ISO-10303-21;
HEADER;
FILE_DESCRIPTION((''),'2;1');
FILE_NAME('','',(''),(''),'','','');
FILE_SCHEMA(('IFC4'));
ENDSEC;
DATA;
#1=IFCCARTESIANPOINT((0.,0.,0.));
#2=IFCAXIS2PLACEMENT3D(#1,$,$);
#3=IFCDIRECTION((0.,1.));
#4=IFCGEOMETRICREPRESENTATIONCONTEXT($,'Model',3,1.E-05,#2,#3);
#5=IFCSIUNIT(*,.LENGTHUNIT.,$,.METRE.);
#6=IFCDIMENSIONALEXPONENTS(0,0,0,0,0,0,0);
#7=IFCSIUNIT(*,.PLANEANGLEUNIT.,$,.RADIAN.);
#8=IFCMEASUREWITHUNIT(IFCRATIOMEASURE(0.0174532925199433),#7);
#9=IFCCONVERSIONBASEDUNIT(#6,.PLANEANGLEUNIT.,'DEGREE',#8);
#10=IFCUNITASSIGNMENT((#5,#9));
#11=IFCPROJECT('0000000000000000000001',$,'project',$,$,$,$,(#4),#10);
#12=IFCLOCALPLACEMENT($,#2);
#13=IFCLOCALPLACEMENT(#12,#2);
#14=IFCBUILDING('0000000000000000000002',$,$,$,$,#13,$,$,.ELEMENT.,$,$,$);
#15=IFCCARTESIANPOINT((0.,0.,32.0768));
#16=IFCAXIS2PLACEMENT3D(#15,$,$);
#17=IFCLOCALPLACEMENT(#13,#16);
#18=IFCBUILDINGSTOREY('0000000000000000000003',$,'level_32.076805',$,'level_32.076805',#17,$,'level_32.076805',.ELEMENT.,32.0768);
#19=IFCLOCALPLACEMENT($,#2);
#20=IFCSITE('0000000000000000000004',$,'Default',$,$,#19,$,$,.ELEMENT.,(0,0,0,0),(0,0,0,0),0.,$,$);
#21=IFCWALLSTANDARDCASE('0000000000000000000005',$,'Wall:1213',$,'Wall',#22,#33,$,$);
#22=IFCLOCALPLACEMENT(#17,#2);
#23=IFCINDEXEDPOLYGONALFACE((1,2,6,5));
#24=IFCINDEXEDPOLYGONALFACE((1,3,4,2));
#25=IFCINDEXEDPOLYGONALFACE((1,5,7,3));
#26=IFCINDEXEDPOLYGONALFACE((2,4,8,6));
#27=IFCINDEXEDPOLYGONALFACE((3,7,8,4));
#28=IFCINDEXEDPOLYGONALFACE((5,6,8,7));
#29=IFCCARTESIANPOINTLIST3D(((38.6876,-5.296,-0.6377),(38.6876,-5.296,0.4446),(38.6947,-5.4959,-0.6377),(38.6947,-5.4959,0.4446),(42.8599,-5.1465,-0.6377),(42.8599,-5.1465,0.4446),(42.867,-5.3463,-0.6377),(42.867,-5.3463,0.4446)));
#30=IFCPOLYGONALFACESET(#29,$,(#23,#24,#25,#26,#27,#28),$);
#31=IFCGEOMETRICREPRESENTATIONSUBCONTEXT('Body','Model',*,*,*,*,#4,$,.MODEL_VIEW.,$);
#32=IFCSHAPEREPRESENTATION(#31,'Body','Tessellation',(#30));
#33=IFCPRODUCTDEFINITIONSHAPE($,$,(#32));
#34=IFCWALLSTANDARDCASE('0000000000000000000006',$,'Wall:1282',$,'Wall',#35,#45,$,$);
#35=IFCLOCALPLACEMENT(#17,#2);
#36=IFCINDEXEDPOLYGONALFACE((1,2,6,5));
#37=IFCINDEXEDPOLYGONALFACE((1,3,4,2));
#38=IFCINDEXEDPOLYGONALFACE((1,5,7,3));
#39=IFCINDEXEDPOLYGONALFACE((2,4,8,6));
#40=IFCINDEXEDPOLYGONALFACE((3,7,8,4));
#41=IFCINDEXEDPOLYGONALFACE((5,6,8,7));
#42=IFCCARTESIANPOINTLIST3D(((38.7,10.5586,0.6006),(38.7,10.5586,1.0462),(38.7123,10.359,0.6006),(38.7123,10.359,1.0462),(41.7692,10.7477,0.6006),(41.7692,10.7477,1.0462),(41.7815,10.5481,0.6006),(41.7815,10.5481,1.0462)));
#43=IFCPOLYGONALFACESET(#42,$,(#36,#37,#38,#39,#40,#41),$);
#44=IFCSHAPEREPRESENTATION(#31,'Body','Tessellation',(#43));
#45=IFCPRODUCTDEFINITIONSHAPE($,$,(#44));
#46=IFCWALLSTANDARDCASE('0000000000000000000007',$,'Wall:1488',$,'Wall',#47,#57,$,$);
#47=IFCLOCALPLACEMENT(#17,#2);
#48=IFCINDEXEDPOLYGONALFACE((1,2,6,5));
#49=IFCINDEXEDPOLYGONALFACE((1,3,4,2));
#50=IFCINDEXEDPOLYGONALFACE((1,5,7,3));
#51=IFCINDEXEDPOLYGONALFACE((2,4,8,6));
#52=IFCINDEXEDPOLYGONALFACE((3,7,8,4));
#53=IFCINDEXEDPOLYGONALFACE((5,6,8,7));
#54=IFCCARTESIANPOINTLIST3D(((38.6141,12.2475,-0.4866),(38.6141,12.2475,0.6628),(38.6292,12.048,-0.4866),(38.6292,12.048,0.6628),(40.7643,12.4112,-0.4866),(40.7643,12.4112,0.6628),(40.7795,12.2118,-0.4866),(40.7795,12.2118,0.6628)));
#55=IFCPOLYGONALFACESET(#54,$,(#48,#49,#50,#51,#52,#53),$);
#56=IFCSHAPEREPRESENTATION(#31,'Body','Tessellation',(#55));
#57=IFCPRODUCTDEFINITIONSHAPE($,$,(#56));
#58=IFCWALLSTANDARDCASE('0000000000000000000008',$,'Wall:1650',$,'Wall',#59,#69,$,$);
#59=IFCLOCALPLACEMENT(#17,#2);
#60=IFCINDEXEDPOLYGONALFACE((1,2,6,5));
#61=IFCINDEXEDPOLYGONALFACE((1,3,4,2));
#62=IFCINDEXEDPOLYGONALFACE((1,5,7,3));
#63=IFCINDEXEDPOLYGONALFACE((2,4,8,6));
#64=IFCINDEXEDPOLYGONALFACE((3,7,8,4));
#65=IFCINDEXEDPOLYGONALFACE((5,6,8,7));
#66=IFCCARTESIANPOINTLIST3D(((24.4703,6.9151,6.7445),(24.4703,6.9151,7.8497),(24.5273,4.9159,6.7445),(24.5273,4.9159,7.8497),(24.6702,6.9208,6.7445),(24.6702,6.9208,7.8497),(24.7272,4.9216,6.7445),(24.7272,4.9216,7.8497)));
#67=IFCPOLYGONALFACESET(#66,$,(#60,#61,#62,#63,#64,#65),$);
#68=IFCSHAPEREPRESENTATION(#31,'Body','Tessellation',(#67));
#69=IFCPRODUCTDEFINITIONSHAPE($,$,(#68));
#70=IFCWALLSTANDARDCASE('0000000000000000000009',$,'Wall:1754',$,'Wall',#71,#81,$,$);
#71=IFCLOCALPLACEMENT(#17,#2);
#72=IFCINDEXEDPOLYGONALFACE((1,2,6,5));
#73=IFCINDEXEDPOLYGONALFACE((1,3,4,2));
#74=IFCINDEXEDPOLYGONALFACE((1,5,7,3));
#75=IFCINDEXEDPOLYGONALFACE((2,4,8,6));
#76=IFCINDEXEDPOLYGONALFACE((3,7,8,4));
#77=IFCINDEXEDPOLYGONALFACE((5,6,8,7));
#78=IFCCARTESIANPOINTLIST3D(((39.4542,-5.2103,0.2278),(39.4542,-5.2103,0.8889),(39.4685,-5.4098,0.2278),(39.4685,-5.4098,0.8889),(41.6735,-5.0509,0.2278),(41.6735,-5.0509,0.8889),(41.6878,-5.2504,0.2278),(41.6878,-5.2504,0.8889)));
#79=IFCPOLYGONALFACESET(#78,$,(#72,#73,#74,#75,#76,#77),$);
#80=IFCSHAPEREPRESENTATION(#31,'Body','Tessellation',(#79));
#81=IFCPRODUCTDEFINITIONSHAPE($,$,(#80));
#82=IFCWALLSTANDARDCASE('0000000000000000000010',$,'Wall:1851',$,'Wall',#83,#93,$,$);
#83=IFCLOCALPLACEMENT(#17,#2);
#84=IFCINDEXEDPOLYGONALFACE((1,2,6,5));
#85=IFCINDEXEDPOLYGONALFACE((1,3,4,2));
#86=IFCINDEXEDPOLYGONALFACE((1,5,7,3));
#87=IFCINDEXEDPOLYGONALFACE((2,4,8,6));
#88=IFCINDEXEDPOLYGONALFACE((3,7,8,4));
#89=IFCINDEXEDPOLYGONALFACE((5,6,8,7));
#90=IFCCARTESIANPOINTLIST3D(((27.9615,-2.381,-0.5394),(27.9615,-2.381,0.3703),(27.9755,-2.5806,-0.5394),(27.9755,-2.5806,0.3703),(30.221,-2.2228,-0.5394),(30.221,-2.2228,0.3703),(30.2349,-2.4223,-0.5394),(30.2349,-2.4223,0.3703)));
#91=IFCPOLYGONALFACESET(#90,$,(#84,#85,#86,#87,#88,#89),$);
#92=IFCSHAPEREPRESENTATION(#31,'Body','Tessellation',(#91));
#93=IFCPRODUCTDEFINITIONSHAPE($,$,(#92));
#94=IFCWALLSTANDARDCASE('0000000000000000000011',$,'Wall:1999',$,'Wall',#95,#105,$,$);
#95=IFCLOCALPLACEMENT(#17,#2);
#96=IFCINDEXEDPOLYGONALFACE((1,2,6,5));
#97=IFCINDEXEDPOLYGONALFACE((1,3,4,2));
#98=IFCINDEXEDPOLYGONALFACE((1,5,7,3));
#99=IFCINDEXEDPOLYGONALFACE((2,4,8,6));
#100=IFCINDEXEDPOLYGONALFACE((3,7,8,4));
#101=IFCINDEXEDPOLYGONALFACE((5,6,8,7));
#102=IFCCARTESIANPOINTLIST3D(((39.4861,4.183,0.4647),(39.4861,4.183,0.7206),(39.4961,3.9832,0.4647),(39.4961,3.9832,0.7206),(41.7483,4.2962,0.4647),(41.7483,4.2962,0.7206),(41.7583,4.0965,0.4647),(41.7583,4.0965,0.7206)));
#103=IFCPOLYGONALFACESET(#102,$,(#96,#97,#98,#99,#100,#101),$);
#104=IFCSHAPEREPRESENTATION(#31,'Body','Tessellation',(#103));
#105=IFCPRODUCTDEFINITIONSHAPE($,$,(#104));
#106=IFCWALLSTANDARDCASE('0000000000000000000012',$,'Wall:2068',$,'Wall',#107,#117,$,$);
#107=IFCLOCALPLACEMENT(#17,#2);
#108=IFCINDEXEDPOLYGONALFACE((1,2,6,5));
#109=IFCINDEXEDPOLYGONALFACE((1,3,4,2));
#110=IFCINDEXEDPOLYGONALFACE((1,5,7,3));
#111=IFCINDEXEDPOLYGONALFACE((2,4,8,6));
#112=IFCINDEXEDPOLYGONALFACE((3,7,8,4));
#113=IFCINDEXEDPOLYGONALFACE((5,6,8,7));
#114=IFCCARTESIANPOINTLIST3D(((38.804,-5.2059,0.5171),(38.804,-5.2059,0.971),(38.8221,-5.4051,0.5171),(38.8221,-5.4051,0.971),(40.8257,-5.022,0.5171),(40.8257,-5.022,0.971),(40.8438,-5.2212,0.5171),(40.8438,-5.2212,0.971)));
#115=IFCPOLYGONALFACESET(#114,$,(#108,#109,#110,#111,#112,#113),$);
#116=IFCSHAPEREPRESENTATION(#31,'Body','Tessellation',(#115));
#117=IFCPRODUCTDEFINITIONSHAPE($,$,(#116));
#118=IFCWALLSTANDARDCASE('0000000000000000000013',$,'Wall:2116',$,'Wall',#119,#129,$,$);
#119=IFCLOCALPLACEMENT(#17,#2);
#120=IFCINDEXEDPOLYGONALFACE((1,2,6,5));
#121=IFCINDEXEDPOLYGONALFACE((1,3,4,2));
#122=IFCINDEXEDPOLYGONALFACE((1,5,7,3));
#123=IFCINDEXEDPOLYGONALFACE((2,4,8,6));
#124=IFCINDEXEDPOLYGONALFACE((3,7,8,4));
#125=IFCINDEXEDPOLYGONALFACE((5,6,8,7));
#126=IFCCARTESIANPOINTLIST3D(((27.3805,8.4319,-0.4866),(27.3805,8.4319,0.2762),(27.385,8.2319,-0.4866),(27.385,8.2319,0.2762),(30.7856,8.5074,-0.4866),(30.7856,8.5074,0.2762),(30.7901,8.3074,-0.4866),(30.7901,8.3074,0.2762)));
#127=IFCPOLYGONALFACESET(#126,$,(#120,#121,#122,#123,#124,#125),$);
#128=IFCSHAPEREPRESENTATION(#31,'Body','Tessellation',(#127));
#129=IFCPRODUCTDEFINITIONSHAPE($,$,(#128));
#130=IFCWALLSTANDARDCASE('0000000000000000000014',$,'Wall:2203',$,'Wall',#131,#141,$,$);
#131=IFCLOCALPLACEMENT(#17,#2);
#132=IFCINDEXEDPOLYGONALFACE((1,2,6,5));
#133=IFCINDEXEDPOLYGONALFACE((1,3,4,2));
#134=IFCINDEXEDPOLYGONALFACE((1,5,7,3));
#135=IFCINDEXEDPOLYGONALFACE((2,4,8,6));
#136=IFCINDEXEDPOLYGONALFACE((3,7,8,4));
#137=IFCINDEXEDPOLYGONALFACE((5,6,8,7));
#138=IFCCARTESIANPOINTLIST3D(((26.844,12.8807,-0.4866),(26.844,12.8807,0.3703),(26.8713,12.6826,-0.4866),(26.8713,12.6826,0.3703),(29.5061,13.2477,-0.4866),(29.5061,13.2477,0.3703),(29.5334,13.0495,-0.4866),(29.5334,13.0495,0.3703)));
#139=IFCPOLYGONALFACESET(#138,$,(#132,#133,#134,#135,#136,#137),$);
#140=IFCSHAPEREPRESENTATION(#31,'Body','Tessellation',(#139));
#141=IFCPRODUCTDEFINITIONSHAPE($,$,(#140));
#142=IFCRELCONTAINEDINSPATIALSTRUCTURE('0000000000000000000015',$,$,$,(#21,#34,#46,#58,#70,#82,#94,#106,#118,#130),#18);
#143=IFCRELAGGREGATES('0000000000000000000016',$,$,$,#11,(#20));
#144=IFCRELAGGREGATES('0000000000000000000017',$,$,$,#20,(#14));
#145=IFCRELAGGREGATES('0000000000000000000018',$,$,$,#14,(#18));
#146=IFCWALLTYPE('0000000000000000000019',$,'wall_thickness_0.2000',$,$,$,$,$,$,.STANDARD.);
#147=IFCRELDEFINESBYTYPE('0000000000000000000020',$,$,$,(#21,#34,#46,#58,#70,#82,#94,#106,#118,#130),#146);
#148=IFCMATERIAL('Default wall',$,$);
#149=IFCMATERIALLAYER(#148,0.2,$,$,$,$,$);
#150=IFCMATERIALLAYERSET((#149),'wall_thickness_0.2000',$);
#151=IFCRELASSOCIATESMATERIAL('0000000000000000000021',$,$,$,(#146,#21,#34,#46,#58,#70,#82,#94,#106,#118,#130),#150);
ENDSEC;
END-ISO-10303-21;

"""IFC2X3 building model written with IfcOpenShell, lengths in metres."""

from ifc_helpers import new_model, entity, si_unit, converted_unit, direction, frame, origin, place, context, subcontext, project, spatial, polyline, outline, extrude, material, layer, layer_set, layer_usage, type_object, element, save


model = new_model("IFC2X3")

# Units and contexts
model_context = context("Model", 3, precision=1e-05, world=origin(), true_north=direction((0.0, 1.0)))
body_context = subcontext(model_context, "Body", "Model", "MODEL_VIEW")
ifc_project = project(units=[si_unit("LENGTHUNIT", "METRE"), converted_unit("PLANEANGLEUNIT", "DEGREE", entity("IfcRatioMeasure", 0.0174532925199433), si_unit("PLANEANGLEUNIT", "RADIAN"), dimensions=[0, 0, 0, 0, 0, 0, 0])], contexts=[model_context])

# Site, building, storey
site_placement = place(None, origin())
site = spatial("IfcSite", under=ifc_project, at=site_placement, Name="Default", CompositionType="ELEMENT", RefLatitude=(0, 0, 0, 0), RefLongitude=(0, 0, 0, 0), RefElevation=0.0)
placement_1 = place(None, origin())
building_placement = place(placement_1, origin())
building = spatial("IfcBuilding", under=site, at=building_placement, CompositionType="ELEMENT")
storey_placement = place(building_placement, frame((0.0, 0.0, 32.0768)))
storey = spatial("IfcBuildingStorey", under=building, at=storey_placement, Name="level_32.076805", ObjectType="level_32.076805", LongName="level_32.076805", CompositionType="ELEMENT", Elevation=32.0768)

# Shared definitions
ifc_material_1 = material(Name="Default wall")
ifc_layer = layer(ifc_material_1, 0.2)
ifc_layer_set = layer_set([ifc_layer], Name="wall_thickness_0.2000")
ifc_layer_usage = layer_usage(ifc_layer_set, "AXIS2", "POSITIVE", -0.1)
wall_type = type_object("IfcWallType", Name="wall_thickness_0.2000", PredefinedType="STANDARD", material=ifc_layer_set)

# Walls
placement_2 = place(building_placement, frame((0.0, 0.0, 31.4391)))
wall_1_placement = place(placement_2, frame((38.6911, -5.3959, 0.0), z_axis=(0.0, 0.0, 1.0), x_axis=(0.999358, 0.03582, 0.0)))
element("IfcWallStandardCase", 1, at=wall_1_placement, inside=storey, type_object=wall_type, material=ifc_layer_usage, Name="Wall:1213", ObjectType="Wall", context=body_context, shape_type="SweptSolid", body=[
    extrude(outline(polyline([(4.175, -0.1), (4.175, 0.1), (0.0, 0.1), (0.0, -0.1), (4.175, -0.1)])), origin(), (0.0, 0.0, 1.0), 1.0823),
])
placement_3 = place(building_placement, frame((0.0, 0.0, 32.6774)))
wall_2_placement = place(placement_3, frame((38.7062, 10.4588, 0.0), z_axis=(0.0, 0.0, 1.0), x_axis=(0.998107, 0.061505, 0.0)))
element("IfcWallStandardCase", 2, at=wall_2_placement, inside=storey, type_object=wall_type, material=ifc_layer_usage, Name="Wall:1282", ObjectType="Wall", context=body_context, shape_type="SweptSolid", body=[
    extrude(outline(polyline([(3.075, -0.1), (3.075, 0.1), (0.0, 0.1), (0.0, -0.1), (3.075, -0.1)])), origin(), (0.0, 0.0, 1.0), 0.4456),
])
placement_4 = place(building_placement, frame((0.0, 0.0, 31.5902)))
wall_3_placement = place(placement_4, frame((38.6216, 12.1477, 0.0), z_axis=(0.0, 0.0, 1.0), x_axis=(0.997112, 0.075948, 0.0)))
element("IfcWallStandardCase", 3, at=wall_3_placement, inside=storey, type_object=wall_type, material=ifc_layer_usage, Name="Wall:1488", ObjectType="Wall", context=body_context, shape_type="SweptSolid", body=[
    extrude(outline(polyline([(2.1565, -0.1), (2.1565, 0.1), (0.0, 0.1), (0.0, -0.1), (2.1565, -0.1)])), origin(), (0.0, 0.0, 1.0), 1.1494),
])
placement_5 = place(building_placement, frame((0.0, 0.0, 38.8213)))
wall_4_placement = place(placement_5, frame((24.6272, 4.9188, 0.0), z_axis=(0.0, 0.0, 1.0), x_axis=(-0.028492, 0.999594, 0.0)))
element("IfcWallStandardCase", 4, at=wall_4_placement, inside=storey, type_object=wall_type, material=ifc_layer_usage, Name="Wall:1650", ObjectType="Wall", context=body_context, shape_type="SweptSolid", body=[
    extrude(outline(polyline([(2.0, -0.1), (2.0, 0.1), (0.0, 0.1), (0.0, -0.1), (2.0, -0.1)])), origin(), (0.0, 0.0, 1.0), 1.1052),
])
placement_6 = place(building_placement, frame((0.0, 0.0, 32.3046)))
wall_5_placement = place(placement_6, frame((39.4613, -5.3101, 0.0), z_axis=(0.0, 0.0, 1.0), x_axis=(0.99743, 0.071653, 0.0)))
element("IfcWallStandardCase", 5, at=wall_5_placement, inside=storey, type_object=wall_type, material=ifc_layer_usage, Name="Wall:1754", ObjectType="Wall", context=body_context, shape_type="SweptSolid", body=[
    extrude(outline(polyline([(2.225, -0.1), (2.225, 0.1), (0.0, 0.1), (0.0, -0.1), (2.225, -0.1)])), origin(), (0.0, 0.0, 1.0), 0.6611),
])
placement_7 = place(building_placement, frame((0.0, 0.0, 31.5374)))
wall_6_placement = place(placement_7, frame((27.9685, -2.4808, 0.0), z_axis=(0.0, 0.0, 1.0), x_axis=(0.997557, 0.069863, 0.0)))
element("IfcWallStandardCase", 6, at=wall_6_placement, inside=storey, type_object=wall_type, material=ifc_layer_usage, Name="Wall:1851", ObjectType="Wall", context=body_context, shape_type="SweptSolid", body=[
    extrude(outline(polyline([(2.265, -0.1), (2.265, 0.1), (0.0, 0.1), (0.0, -0.1), (2.265, -0.1)])), origin(), (0.0, 0.0, 1.0), 0.9097),
])
placement_8 = place(building_placement, frame((0.0, 0.0, 32.5415)))
wall_7_placement = place(placement_8, frame((39.4911, 4.0831, 0.0), z_axis=(0.0, 0.0, 1.0), x_axis=(0.998748, 0.050016, 0.0)))
element("IfcWallStandardCase", 7, at=wall_7_placement, inside=storey, type_object=wall_type, material=ifc_layer_usage, Name="Wall:1999", ObjectType="Wall", context=body_context, shape_type="SweptSolid", body=[
    extrude(outline(polyline([(2.265, -0.1), (2.265, 0.1), (0.0, 0.1), (0.0, -0.1), (2.265, -0.1)])), origin(), (0.0, 0.0, 1.0), 0.2559),
])
placement_9 = place(building_placement, frame((0.0, 0.0, 32.5939)))
wall_8_placement = place(placement_9, frame((38.8131, -5.3055, 0.0), z_axis=(0.0, 0.0, 1.0), x_axis=(0.995888, 0.090597, 0.0)))
element("IfcWallStandardCase", 8, at=wall_8_placement, inside=storey, type_object=wall_type, material=ifc_layer_usage, Name="Wall:2068", ObjectType="Wall", context=body_context, shape_type="SweptSolid", body=[
    extrude(outline(polyline([(2.03, -0.1), (2.03, 0.1), (0.0, 0.1), (0.0, -0.1), (2.03, -0.1)])), origin(), (0.0, 0.0, 1.0), 0.4539),
])
placement_10 = place(building_placement, frame((0.0, 0.0, 31.5902)))
wall_9_placement = place(placement_10, frame((27.3828, 8.3319, 0.0), z_axis=(0.0, 0.0, 1.0), x_axis=(0.999754, 0.022166, 0.0)))
element("IfcWallStandardCase", 9, at=wall_9_placement, inside=storey, type_object=wall_type, material=ifc_layer_usage, Name="Wall:2116", ObjectType="Wall", context=body_context, shape_type="SweptSolid", body=[
    extrude(outline(polyline([(3.4059, -0.1), (3.4059, 0.1), (0.0, 0.1), (0.0, -0.1), (3.4059, -0.1)])), origin(), (0.0, 0.0, 1.0), 0.7628),
])
placement_11 = place(building_placement, frame((0.0, 0.0, 31.5902)))
wall_10_placement = place(placement_11, frame((26.8576, 12.7816, 0.0), z_axis=(0.0, 0.0, 1.0), x_axis=(0.990632, 0.136558, 0.0)))
element("IfcWallStandardCase", 10, at=wall_10_placement, inside=storey, type_object=wall_type, material=ifc_layer_usage, Name="Wall:2203", ObjectType="Wall", context=body_context, shape_type="SweptSolid", body=[
    extrude(outline(polyline([(2.6873, -0.1), (2.6873, 0.1), (0.0, 0.1), (0.0, -0.1), (2.6873, -0.1)])), origin(), (0.0, 0.0, 1.0), 0.8569),
])

save(model, "model.ifc")
